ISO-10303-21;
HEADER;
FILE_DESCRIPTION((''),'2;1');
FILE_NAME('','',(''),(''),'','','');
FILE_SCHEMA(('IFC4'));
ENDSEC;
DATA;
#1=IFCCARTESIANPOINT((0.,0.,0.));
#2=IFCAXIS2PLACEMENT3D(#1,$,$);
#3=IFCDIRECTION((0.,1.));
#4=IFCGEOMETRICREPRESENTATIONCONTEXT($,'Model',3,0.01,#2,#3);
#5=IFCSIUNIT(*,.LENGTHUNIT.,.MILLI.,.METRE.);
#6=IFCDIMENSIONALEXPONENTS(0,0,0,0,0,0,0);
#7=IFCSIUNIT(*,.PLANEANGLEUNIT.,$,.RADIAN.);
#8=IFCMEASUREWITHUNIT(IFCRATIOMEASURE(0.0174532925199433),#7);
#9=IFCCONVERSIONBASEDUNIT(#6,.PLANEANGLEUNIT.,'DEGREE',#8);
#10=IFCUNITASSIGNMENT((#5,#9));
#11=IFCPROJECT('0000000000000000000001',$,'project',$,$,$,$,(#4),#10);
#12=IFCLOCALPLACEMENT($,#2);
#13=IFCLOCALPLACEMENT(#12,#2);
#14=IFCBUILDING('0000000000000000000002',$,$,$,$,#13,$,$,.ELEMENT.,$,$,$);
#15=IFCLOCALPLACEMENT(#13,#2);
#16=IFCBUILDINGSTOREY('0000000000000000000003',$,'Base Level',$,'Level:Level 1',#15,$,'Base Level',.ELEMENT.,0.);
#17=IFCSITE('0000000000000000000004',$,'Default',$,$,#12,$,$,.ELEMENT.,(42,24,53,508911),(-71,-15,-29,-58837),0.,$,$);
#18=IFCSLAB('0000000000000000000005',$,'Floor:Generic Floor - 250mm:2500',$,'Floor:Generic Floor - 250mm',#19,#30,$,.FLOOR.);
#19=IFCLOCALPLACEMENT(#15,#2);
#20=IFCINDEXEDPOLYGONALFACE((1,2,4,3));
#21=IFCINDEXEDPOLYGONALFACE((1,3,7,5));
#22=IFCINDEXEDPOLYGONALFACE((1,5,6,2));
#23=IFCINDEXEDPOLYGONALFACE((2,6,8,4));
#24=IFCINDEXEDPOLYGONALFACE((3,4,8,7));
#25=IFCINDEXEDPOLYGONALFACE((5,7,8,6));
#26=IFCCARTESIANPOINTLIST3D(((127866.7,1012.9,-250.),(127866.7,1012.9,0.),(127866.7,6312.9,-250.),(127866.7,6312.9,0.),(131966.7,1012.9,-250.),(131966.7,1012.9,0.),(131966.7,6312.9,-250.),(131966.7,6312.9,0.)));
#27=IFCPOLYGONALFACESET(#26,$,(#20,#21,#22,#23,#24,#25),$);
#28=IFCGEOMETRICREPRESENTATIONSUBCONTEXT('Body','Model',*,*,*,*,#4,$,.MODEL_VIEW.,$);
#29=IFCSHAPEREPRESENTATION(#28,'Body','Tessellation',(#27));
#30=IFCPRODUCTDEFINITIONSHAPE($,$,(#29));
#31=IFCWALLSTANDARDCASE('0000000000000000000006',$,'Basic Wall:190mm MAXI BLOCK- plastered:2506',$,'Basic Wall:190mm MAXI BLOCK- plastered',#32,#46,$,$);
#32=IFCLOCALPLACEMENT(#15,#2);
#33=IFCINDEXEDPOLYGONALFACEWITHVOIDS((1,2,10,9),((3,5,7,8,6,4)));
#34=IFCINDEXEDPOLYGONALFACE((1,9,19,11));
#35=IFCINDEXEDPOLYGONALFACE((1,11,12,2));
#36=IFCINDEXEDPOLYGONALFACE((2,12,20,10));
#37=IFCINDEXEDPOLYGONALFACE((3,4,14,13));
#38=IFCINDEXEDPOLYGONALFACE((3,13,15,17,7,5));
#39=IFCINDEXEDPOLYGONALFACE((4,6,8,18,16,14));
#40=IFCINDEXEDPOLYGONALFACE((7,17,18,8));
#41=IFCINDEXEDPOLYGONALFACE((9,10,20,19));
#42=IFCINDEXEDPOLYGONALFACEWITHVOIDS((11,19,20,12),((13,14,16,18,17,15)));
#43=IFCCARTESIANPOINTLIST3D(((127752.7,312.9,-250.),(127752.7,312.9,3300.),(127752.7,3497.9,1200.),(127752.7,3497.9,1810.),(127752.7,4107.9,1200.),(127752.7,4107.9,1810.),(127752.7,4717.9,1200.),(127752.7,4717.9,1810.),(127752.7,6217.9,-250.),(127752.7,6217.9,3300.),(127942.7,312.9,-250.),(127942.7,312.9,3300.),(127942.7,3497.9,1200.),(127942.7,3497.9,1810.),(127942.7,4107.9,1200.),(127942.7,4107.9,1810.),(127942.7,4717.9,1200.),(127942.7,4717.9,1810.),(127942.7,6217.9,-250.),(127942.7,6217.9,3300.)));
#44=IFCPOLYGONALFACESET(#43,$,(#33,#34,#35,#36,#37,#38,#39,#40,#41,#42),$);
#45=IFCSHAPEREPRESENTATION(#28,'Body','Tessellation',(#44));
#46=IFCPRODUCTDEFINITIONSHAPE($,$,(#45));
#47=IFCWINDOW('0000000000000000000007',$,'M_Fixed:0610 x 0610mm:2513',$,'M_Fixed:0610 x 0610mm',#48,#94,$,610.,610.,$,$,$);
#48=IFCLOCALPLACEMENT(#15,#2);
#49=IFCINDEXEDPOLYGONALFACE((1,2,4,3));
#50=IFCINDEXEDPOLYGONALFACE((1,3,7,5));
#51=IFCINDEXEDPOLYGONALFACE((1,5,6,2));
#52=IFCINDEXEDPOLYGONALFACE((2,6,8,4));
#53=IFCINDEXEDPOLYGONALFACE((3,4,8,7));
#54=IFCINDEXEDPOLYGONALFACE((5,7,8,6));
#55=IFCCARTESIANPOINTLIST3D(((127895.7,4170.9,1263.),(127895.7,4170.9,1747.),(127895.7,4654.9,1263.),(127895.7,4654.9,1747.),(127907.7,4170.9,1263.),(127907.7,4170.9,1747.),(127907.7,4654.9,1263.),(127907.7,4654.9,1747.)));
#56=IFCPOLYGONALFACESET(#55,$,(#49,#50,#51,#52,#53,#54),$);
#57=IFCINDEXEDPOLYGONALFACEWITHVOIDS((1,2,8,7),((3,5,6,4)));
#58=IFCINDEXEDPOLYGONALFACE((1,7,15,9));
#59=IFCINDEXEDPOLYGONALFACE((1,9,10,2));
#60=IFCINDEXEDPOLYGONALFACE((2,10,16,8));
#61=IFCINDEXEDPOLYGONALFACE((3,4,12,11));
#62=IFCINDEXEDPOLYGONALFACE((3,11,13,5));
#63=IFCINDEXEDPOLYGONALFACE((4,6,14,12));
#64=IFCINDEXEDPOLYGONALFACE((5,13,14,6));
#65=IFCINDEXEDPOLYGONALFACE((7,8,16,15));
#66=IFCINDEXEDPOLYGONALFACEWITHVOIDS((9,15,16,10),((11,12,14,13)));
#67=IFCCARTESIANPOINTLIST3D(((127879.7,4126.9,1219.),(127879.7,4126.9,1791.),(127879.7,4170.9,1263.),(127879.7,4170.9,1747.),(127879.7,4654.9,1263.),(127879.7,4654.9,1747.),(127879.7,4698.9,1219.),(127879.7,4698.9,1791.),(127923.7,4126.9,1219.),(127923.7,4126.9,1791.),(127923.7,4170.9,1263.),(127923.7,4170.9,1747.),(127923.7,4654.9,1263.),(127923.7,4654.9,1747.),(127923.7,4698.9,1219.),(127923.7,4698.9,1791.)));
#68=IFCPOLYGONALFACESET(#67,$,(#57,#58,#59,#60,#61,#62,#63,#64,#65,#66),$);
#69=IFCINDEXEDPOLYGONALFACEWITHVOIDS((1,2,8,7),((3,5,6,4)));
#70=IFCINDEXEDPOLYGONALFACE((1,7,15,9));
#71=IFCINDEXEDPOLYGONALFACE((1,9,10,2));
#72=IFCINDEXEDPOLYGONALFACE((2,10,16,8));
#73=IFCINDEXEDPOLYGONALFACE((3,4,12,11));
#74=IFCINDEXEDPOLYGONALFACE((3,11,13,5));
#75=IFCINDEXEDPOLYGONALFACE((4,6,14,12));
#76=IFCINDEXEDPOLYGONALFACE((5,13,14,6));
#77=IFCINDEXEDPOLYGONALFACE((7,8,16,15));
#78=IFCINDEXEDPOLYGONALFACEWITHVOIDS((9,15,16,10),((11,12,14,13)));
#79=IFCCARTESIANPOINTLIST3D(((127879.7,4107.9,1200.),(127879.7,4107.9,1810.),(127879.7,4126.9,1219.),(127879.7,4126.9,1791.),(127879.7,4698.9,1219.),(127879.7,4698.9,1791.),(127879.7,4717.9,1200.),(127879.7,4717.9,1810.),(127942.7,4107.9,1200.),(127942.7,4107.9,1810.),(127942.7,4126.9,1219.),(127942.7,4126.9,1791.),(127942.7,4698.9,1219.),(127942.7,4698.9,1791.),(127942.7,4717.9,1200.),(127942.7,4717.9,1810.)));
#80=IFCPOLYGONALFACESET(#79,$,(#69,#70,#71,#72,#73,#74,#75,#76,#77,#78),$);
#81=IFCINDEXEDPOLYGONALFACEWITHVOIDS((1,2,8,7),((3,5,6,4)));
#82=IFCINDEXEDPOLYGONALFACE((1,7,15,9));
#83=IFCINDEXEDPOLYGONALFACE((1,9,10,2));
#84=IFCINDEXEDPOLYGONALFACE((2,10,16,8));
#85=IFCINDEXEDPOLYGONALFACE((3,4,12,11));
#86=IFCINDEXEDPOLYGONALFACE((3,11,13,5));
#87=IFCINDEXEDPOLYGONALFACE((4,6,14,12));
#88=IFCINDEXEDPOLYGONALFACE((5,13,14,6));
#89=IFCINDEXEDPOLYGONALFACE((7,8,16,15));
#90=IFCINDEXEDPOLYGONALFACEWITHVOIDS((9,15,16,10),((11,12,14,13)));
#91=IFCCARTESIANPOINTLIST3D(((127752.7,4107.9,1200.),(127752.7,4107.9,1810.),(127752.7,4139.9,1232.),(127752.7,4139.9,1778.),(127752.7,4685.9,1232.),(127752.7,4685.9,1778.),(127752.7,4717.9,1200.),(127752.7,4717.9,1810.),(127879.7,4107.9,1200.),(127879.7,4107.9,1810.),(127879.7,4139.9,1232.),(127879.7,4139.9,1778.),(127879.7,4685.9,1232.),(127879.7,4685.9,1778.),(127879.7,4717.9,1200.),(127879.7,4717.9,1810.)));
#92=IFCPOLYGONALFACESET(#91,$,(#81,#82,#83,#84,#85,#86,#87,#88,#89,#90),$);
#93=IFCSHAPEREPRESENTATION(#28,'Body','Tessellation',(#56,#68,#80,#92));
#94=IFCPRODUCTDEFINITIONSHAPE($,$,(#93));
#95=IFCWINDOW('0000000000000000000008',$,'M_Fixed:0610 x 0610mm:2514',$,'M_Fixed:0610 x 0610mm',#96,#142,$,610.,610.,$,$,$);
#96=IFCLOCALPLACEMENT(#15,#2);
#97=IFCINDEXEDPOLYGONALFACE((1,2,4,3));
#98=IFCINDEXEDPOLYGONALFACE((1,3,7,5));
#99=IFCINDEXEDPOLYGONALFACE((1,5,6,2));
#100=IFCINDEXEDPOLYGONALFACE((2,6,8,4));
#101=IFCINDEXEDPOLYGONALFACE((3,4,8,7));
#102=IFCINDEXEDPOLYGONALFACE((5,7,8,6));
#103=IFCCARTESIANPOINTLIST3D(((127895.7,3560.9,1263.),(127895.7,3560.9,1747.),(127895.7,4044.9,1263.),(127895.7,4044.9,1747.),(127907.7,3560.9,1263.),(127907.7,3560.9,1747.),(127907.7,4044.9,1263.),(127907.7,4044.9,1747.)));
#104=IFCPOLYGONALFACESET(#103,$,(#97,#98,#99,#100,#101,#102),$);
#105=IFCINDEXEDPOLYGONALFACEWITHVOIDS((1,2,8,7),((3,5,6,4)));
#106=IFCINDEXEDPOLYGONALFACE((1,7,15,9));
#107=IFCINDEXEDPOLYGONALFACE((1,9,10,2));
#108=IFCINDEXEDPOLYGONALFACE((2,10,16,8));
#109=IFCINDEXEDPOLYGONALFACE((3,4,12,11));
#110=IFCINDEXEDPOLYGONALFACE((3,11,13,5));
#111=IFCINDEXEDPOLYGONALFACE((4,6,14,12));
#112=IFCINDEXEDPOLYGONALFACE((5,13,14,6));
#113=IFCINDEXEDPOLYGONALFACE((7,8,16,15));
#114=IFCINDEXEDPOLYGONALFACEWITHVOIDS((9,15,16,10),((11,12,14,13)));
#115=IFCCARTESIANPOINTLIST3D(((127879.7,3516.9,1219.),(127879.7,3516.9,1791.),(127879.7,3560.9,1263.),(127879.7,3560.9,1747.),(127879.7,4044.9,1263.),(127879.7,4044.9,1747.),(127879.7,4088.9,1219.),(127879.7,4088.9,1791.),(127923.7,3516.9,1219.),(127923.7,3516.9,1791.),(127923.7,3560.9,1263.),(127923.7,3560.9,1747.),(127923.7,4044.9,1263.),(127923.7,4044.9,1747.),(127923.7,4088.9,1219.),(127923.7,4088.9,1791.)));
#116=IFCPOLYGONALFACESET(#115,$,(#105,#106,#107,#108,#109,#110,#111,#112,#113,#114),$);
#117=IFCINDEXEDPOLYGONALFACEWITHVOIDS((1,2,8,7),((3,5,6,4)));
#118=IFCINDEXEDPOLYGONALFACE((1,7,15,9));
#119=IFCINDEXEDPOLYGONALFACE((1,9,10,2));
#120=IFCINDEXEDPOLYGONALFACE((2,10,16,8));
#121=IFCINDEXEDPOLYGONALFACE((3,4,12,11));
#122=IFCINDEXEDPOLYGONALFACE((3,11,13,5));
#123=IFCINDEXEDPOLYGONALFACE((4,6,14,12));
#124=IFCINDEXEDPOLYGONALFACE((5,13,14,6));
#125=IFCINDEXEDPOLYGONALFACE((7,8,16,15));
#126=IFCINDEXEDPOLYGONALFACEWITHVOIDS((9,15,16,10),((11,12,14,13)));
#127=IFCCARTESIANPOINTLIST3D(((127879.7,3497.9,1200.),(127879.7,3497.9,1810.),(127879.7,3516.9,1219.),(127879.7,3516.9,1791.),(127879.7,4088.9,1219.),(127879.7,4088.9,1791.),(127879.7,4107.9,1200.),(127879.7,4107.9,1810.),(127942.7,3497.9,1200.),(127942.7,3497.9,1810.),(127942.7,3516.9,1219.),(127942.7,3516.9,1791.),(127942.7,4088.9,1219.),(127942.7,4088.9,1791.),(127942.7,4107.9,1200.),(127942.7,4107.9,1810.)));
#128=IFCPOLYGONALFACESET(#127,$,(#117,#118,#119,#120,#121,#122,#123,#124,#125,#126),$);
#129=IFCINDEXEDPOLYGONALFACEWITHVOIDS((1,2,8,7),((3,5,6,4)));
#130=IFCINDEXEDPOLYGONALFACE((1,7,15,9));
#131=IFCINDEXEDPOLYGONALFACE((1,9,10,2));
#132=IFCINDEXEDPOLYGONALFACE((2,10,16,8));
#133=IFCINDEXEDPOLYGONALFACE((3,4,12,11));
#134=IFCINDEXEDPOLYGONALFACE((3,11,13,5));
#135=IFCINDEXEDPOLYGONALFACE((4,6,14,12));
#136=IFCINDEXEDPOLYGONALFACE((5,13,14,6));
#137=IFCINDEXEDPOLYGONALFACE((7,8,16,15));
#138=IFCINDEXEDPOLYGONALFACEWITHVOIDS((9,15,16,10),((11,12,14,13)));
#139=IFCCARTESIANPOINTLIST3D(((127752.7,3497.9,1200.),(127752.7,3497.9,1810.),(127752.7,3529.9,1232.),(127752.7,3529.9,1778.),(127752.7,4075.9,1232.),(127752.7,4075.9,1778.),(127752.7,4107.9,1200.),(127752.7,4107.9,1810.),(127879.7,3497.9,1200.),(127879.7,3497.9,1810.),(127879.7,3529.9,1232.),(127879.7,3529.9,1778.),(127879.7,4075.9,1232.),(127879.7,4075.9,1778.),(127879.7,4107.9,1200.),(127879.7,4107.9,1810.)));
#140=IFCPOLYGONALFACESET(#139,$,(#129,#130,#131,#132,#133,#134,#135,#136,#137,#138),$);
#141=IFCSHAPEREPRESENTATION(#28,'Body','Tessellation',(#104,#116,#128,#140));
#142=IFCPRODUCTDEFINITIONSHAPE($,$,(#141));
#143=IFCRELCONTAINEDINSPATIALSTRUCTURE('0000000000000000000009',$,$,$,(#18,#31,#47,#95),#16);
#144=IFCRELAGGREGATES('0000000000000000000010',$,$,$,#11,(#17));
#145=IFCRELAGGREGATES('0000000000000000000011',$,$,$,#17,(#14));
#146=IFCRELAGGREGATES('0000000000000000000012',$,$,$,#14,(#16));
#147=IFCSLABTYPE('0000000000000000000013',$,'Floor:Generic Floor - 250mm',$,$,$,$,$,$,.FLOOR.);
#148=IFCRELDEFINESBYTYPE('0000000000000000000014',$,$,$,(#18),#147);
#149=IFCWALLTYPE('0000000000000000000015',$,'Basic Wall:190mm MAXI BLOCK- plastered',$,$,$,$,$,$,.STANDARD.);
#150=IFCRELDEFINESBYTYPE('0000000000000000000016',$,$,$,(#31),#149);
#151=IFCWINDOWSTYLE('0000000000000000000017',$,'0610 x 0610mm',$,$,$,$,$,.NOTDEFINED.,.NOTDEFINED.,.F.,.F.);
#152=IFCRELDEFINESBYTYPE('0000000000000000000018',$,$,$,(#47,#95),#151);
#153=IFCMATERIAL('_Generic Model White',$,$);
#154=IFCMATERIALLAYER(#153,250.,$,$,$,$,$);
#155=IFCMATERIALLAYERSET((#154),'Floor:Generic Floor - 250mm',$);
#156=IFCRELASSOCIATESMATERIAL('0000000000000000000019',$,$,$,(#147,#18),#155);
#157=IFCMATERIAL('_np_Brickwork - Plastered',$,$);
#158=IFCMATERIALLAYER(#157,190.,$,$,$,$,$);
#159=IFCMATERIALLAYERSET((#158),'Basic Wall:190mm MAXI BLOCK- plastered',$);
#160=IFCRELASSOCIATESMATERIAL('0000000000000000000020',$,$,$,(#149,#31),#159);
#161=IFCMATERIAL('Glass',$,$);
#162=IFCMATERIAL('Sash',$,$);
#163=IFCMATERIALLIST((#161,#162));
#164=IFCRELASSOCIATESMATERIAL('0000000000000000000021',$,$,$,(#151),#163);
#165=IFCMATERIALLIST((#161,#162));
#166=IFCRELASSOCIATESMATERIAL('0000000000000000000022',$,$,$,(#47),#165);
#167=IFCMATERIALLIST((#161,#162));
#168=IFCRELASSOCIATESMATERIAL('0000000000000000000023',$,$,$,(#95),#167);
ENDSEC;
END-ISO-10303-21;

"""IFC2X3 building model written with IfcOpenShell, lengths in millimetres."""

from ifc_helpers import new_model, entity, si_unit, converted_unit, direction, frame, frame_2d, origin, place, context, subcontext, project, spatial, polyline, rectangle, outline, extrude, source, transform, mapped, material, material_list, layer, layer_set, layer_usage, type_object, type_shapes, element, fill, save


model = new_model("IFC2X3")

# Units and contexts
model_context = context("Model", 3, precision=0.01, world=origin(), true_north=direction((0.0, 1.0)))
body_context = subcontext(model_context, "Body", "Model", "MODEL_VIEW")
ifc_project = project(units=[si_unit("LENGTHUNIT", "METRE", prefix="MILLI"), converted_unit("PLANEANGLEUNIT", "DEGREE", entity("IfcRatioMeasure", 0.0174532925199433), si_unit("PLANEANGLEUNIT", "RADIAN"), dimensions=[0, 0, 0, 0, 0, 0, 0])], contexts=[model_context])

# Site, building, storey
site_placement = place(None, origin())
site = spatial("IfcSite", under=ifc_project, at=site_placement, Name="Default", CompositionType="ELEMENT", RefLatitude=(42, 24, 53, 508911), RefLongitude=(-71, -15, -29, -58837), RefElevation=0.0)
building_placement = place(site_placement, origin())
building = spatial("IfcBuilding", under=site, at=building_placement, CompositionType="ELEMENT")
storey_placement = place(building_placement, origin())
storey = spatial("IfcBuildingStorey", under=building, at=storey_placement, Name="Base Level", ObjectType="Level:Level 1", LongName="Base Level", CompositionType="ELEMENT", Elevation=0.0)

# Slab
ifc_material_1 = material(Name="_Generic Model White")
ifc_layer_1 = layer(ifc_material_1, 250.0)
ifc_layer_set_1 = layer_set([ifc_layer_1], Name="Floor:Generic Floor - 250mm")
ifc_layer_usage_1 = layer_usage(ifc_layer_set_1, "AXIS3", "POSITIVE", 0.0)
slab_type = type_object("IfcSlabType", Name="Floor:Generic Floor - 250mm", PredefinedType="FLOOR", material=ifc_layer_set_1)
slab_placement = place(building_placement, origin())
element("IfcSlab", 1, at=slab_placement, inside=storey, type_object=slab_type, material=ifc_layer_usage_1, Name="Floor:Generic Floor - 250mm:2500", ObjectType="Floor:Generic Floor - 250mm", PredefinedType="FLOOR", context=body_context, shape_type="SweptSolid", body=[
    extrude(rectangle(XDim=5300.0, YDim=4100.0, at=frame_2d((0.0, 0.0), x_axis=(1.0, 0.0))), frame((129916.7, 3662.9, 0.0), z_axis=(0.0, 0.0, -1.0), x_axis=(0.0, 1.0, 0.0)), (0.0, 0.0, 1.0), 250.0),
])

# Wall, openings, windows
ifc_material_2 = material(Name="_np_Brickwork - Plastered")
ifc_layer_2 = layer(ifc_material_2, 190.0)
ifc_layer_set_2 = layer_set([ifc_layer_2], Name="Basic Wall:190mm MAXI BLOCK- plastered")
ifc_layer_usage_2 = layer_usage(ifc_layer_set_2, "AXIS2", "NEGATIVE", 95.0)
wall_type = type_object("IfcWallType", Name="Basic Wall:190mm MAXI BLOCK- plastered", PredefinedType="STANDARD", material=ifc_layer_set_2)
wall_placement = place(building_placement, frame((127847.7, 312.9, -250.0), z_axis=(0.0, 0.0, 1.0), x_axis=(0.0, 1.0, 0.0)))
wall = element("IfcWallStandardCase", 2, at=wall_placement, inside=storey, type_object=wall_type, material=ifc_layer_usage_2, Name="Basic Wall:190mm MAXI BLOCK- plastered:2506", ObjectType="Basic Wall:190mm MAXI BLOCK- plastered", context=body_context, shape_type="SweptSolid", body=[
    extrude(rectangle(XDim=5905.0, YDim=190.0, at=frame_2d((2952.5, 0.0), x_axis=(-1.0, 0.0))), origin(), (0.0, 0.0, 1.0), 3550.0),
])
opening_1_placement = place(wall_placement, frame((4405.0, 95.0, 1450.0)))
opening_1 = element("IfcOpeningElement", 3, at=opening_1_placement, cuts=wall, ObjectType="Opening", context=body_context, shape_type="SweptSolid", body=[
    extrude(rectangle(XDim=610.0, YDim=610.0, at=frame_2d((305.0, 305.0), x_axis=(1.0, 0.0))), frame((0.0, 0.0, 0.0), z_axis=(0.0, -1.0, 0.0), x_axis=(0.0, 0.0, 1.0)), (0.0, 0.0, 1.0), 190.0),
])
opening_2_placement = place(wall_placement, frame((3795.0, 95.0, 1450.0)))
opening_2 = element("IfcOpeningElement", 4, at=opening_2_placement, cuts=wall, ObjectType="Opening", context=body_context, shape_type="SweptSolid", body=[
    extrude(rectangle(XDim=610.0, YDim=610.0, at=frame_2d((305.0, 305.0), x_axis=(1.0, 0.0))), frame((0.0, 0.0, 0.0), z_axis=(0.0, -1.0, 0.0), x_axis=(0.0, 0.0, 1.0)), (0.0, 0.0, 1.0), 190.0),
])
ifc_material_3 = material(Name="Glass")
ifc_material_4 = material(Name="Sash")
ifc_material_list_1 = material_list([ifc_material_3, ifc_material_4])
ifc_material_list_2 = material_list([ifc_material_3, ifc_material_4])
window_style = type_object("IfcWindowStyle", Name="0610 x 0610mm", ConstructionType="NOTDEFINED", OperationType="NOTDEFINED", ParameterTakesPrecedence=False, Sizeable=False, material=ifc_material_list_2)
shared_shape_1 = source(origin(), body_context, "Body", "SweptSolid", [
    extrude(rectangle(XDim=12.0, YDim=484.0, at=frame_2d((0.0, 0.0), x_axis=(1.0, 0.0))), frame((305.0, 149.0, 63.0), z_axis=(0.0, 0.0, 1.0), x_axis=(0.0, -1.0, 0.0)), (0.0, 0.0, 1.0), 484.0),
    extrude(outline(polyline([(-286.0, -286.0), (286.0, -286.0), (286.0, 286.0), (-286.0, 286.0), (-286.0, -286.0)]), holes=[polyline([(-242.0, -242.0), (-242.0, 242.0), (242.0, 242.0), (242.0, -242.0), (-242.0, -242.0)])]), frame((305.0, 127.0, 305.0), z_axis=(0.0, 1.0, 0.0), x_axis=(1.0, 0.0, 0.0)), (0.0, 0.0, 1.0), 44.0),
    extrude(outline(polyline([(-305.0, -305.0), (305.0, -305.0), (305.0, 305.0), (-305.0, 305.0), (-305.0, -305.0)]), holes=[polyline([(-286.0, -286.0), (-286.0, 286.0), (286.0, 286.0), (286.0, -286.0), (-286.0, -286.0)])]), frame((305.0, 127.0, 305.0), z_axis=(0.0, 1.0, 0.0), x_axis=(1.0, 0.0, 0.0)), (0.0, 0.0, 1.0), 63.0),
    extrude(outline(polyline([(-305.0, -305.0), (305.0, -305.0), (305.0, 305.0), (-305.0, 305.0), (-305.0, -305.0)]), holes=[polyline([(-273.0, -273.0), (-273.0, 273.0), (273.0, 273.0), (273.0, -273.0), (-273.0, -273.0)])]), frame((305.0, 0.0, 305.0), z_axis=(0.0, 1.0, 0.0), x_axis=(1.0, 0.0, 0.0)), (0.0, 0.0, 1.0), 127.0),
])
type_shapes(window_style, [shared_shape_1])
window_1_placement = place(opening_1_placement, frame((0.0, 0.0, 0.0), z_axis=(0.0, 0.0, 1.0), x_axis=(-1.0, 0.0, 0.0)))
window_1 = element("IfcWindow", 5, at=window_1_placement, inside=storey, type_object=window_style, material=ifc_material_list_1, Name="M_Fixed:0610 x 0610mm:2513", ObjectType="M_Fixed:0610 x 0610mm", OverallHeight=610.0, OverallWidth=610.0, context=body_context, shape_type="MappedRepresentation", body=[
    mapped(shared_shape_1, transform((0.0, 0.0, 0.0), scale=1.0)),
])
fill(opening_1, window_1)
ifc_material_list_3 = material_list([ifc_material_3, ifc_material_4])
window_2_placement = place(opening_2_placement, frame((0.0, 0.0, 0.0), z_axis=(0.0, 0.0, 1.0), x_axis=(-1.0, 0.0, 0.0)))
window_2 = element("IfcWindow", 6, at=window_2_placement, inside=storey, type_object=window_style, material=ifc_material_list_3, Name="M_Fixed:0610 x 0610mm:2514", ObjectType="M_Fixed:0610 x 0610mm", OverallHeight=610.0, OverallWidth=610.0, context=body_context, shape_type="MappedRepresentation", body=[
    mapped(shared_shape_1, transform((0.0, 0.0, 0.0), scale=1.0)),
])
fill(opening_2, window_2)

save(model, "model.ifc")
